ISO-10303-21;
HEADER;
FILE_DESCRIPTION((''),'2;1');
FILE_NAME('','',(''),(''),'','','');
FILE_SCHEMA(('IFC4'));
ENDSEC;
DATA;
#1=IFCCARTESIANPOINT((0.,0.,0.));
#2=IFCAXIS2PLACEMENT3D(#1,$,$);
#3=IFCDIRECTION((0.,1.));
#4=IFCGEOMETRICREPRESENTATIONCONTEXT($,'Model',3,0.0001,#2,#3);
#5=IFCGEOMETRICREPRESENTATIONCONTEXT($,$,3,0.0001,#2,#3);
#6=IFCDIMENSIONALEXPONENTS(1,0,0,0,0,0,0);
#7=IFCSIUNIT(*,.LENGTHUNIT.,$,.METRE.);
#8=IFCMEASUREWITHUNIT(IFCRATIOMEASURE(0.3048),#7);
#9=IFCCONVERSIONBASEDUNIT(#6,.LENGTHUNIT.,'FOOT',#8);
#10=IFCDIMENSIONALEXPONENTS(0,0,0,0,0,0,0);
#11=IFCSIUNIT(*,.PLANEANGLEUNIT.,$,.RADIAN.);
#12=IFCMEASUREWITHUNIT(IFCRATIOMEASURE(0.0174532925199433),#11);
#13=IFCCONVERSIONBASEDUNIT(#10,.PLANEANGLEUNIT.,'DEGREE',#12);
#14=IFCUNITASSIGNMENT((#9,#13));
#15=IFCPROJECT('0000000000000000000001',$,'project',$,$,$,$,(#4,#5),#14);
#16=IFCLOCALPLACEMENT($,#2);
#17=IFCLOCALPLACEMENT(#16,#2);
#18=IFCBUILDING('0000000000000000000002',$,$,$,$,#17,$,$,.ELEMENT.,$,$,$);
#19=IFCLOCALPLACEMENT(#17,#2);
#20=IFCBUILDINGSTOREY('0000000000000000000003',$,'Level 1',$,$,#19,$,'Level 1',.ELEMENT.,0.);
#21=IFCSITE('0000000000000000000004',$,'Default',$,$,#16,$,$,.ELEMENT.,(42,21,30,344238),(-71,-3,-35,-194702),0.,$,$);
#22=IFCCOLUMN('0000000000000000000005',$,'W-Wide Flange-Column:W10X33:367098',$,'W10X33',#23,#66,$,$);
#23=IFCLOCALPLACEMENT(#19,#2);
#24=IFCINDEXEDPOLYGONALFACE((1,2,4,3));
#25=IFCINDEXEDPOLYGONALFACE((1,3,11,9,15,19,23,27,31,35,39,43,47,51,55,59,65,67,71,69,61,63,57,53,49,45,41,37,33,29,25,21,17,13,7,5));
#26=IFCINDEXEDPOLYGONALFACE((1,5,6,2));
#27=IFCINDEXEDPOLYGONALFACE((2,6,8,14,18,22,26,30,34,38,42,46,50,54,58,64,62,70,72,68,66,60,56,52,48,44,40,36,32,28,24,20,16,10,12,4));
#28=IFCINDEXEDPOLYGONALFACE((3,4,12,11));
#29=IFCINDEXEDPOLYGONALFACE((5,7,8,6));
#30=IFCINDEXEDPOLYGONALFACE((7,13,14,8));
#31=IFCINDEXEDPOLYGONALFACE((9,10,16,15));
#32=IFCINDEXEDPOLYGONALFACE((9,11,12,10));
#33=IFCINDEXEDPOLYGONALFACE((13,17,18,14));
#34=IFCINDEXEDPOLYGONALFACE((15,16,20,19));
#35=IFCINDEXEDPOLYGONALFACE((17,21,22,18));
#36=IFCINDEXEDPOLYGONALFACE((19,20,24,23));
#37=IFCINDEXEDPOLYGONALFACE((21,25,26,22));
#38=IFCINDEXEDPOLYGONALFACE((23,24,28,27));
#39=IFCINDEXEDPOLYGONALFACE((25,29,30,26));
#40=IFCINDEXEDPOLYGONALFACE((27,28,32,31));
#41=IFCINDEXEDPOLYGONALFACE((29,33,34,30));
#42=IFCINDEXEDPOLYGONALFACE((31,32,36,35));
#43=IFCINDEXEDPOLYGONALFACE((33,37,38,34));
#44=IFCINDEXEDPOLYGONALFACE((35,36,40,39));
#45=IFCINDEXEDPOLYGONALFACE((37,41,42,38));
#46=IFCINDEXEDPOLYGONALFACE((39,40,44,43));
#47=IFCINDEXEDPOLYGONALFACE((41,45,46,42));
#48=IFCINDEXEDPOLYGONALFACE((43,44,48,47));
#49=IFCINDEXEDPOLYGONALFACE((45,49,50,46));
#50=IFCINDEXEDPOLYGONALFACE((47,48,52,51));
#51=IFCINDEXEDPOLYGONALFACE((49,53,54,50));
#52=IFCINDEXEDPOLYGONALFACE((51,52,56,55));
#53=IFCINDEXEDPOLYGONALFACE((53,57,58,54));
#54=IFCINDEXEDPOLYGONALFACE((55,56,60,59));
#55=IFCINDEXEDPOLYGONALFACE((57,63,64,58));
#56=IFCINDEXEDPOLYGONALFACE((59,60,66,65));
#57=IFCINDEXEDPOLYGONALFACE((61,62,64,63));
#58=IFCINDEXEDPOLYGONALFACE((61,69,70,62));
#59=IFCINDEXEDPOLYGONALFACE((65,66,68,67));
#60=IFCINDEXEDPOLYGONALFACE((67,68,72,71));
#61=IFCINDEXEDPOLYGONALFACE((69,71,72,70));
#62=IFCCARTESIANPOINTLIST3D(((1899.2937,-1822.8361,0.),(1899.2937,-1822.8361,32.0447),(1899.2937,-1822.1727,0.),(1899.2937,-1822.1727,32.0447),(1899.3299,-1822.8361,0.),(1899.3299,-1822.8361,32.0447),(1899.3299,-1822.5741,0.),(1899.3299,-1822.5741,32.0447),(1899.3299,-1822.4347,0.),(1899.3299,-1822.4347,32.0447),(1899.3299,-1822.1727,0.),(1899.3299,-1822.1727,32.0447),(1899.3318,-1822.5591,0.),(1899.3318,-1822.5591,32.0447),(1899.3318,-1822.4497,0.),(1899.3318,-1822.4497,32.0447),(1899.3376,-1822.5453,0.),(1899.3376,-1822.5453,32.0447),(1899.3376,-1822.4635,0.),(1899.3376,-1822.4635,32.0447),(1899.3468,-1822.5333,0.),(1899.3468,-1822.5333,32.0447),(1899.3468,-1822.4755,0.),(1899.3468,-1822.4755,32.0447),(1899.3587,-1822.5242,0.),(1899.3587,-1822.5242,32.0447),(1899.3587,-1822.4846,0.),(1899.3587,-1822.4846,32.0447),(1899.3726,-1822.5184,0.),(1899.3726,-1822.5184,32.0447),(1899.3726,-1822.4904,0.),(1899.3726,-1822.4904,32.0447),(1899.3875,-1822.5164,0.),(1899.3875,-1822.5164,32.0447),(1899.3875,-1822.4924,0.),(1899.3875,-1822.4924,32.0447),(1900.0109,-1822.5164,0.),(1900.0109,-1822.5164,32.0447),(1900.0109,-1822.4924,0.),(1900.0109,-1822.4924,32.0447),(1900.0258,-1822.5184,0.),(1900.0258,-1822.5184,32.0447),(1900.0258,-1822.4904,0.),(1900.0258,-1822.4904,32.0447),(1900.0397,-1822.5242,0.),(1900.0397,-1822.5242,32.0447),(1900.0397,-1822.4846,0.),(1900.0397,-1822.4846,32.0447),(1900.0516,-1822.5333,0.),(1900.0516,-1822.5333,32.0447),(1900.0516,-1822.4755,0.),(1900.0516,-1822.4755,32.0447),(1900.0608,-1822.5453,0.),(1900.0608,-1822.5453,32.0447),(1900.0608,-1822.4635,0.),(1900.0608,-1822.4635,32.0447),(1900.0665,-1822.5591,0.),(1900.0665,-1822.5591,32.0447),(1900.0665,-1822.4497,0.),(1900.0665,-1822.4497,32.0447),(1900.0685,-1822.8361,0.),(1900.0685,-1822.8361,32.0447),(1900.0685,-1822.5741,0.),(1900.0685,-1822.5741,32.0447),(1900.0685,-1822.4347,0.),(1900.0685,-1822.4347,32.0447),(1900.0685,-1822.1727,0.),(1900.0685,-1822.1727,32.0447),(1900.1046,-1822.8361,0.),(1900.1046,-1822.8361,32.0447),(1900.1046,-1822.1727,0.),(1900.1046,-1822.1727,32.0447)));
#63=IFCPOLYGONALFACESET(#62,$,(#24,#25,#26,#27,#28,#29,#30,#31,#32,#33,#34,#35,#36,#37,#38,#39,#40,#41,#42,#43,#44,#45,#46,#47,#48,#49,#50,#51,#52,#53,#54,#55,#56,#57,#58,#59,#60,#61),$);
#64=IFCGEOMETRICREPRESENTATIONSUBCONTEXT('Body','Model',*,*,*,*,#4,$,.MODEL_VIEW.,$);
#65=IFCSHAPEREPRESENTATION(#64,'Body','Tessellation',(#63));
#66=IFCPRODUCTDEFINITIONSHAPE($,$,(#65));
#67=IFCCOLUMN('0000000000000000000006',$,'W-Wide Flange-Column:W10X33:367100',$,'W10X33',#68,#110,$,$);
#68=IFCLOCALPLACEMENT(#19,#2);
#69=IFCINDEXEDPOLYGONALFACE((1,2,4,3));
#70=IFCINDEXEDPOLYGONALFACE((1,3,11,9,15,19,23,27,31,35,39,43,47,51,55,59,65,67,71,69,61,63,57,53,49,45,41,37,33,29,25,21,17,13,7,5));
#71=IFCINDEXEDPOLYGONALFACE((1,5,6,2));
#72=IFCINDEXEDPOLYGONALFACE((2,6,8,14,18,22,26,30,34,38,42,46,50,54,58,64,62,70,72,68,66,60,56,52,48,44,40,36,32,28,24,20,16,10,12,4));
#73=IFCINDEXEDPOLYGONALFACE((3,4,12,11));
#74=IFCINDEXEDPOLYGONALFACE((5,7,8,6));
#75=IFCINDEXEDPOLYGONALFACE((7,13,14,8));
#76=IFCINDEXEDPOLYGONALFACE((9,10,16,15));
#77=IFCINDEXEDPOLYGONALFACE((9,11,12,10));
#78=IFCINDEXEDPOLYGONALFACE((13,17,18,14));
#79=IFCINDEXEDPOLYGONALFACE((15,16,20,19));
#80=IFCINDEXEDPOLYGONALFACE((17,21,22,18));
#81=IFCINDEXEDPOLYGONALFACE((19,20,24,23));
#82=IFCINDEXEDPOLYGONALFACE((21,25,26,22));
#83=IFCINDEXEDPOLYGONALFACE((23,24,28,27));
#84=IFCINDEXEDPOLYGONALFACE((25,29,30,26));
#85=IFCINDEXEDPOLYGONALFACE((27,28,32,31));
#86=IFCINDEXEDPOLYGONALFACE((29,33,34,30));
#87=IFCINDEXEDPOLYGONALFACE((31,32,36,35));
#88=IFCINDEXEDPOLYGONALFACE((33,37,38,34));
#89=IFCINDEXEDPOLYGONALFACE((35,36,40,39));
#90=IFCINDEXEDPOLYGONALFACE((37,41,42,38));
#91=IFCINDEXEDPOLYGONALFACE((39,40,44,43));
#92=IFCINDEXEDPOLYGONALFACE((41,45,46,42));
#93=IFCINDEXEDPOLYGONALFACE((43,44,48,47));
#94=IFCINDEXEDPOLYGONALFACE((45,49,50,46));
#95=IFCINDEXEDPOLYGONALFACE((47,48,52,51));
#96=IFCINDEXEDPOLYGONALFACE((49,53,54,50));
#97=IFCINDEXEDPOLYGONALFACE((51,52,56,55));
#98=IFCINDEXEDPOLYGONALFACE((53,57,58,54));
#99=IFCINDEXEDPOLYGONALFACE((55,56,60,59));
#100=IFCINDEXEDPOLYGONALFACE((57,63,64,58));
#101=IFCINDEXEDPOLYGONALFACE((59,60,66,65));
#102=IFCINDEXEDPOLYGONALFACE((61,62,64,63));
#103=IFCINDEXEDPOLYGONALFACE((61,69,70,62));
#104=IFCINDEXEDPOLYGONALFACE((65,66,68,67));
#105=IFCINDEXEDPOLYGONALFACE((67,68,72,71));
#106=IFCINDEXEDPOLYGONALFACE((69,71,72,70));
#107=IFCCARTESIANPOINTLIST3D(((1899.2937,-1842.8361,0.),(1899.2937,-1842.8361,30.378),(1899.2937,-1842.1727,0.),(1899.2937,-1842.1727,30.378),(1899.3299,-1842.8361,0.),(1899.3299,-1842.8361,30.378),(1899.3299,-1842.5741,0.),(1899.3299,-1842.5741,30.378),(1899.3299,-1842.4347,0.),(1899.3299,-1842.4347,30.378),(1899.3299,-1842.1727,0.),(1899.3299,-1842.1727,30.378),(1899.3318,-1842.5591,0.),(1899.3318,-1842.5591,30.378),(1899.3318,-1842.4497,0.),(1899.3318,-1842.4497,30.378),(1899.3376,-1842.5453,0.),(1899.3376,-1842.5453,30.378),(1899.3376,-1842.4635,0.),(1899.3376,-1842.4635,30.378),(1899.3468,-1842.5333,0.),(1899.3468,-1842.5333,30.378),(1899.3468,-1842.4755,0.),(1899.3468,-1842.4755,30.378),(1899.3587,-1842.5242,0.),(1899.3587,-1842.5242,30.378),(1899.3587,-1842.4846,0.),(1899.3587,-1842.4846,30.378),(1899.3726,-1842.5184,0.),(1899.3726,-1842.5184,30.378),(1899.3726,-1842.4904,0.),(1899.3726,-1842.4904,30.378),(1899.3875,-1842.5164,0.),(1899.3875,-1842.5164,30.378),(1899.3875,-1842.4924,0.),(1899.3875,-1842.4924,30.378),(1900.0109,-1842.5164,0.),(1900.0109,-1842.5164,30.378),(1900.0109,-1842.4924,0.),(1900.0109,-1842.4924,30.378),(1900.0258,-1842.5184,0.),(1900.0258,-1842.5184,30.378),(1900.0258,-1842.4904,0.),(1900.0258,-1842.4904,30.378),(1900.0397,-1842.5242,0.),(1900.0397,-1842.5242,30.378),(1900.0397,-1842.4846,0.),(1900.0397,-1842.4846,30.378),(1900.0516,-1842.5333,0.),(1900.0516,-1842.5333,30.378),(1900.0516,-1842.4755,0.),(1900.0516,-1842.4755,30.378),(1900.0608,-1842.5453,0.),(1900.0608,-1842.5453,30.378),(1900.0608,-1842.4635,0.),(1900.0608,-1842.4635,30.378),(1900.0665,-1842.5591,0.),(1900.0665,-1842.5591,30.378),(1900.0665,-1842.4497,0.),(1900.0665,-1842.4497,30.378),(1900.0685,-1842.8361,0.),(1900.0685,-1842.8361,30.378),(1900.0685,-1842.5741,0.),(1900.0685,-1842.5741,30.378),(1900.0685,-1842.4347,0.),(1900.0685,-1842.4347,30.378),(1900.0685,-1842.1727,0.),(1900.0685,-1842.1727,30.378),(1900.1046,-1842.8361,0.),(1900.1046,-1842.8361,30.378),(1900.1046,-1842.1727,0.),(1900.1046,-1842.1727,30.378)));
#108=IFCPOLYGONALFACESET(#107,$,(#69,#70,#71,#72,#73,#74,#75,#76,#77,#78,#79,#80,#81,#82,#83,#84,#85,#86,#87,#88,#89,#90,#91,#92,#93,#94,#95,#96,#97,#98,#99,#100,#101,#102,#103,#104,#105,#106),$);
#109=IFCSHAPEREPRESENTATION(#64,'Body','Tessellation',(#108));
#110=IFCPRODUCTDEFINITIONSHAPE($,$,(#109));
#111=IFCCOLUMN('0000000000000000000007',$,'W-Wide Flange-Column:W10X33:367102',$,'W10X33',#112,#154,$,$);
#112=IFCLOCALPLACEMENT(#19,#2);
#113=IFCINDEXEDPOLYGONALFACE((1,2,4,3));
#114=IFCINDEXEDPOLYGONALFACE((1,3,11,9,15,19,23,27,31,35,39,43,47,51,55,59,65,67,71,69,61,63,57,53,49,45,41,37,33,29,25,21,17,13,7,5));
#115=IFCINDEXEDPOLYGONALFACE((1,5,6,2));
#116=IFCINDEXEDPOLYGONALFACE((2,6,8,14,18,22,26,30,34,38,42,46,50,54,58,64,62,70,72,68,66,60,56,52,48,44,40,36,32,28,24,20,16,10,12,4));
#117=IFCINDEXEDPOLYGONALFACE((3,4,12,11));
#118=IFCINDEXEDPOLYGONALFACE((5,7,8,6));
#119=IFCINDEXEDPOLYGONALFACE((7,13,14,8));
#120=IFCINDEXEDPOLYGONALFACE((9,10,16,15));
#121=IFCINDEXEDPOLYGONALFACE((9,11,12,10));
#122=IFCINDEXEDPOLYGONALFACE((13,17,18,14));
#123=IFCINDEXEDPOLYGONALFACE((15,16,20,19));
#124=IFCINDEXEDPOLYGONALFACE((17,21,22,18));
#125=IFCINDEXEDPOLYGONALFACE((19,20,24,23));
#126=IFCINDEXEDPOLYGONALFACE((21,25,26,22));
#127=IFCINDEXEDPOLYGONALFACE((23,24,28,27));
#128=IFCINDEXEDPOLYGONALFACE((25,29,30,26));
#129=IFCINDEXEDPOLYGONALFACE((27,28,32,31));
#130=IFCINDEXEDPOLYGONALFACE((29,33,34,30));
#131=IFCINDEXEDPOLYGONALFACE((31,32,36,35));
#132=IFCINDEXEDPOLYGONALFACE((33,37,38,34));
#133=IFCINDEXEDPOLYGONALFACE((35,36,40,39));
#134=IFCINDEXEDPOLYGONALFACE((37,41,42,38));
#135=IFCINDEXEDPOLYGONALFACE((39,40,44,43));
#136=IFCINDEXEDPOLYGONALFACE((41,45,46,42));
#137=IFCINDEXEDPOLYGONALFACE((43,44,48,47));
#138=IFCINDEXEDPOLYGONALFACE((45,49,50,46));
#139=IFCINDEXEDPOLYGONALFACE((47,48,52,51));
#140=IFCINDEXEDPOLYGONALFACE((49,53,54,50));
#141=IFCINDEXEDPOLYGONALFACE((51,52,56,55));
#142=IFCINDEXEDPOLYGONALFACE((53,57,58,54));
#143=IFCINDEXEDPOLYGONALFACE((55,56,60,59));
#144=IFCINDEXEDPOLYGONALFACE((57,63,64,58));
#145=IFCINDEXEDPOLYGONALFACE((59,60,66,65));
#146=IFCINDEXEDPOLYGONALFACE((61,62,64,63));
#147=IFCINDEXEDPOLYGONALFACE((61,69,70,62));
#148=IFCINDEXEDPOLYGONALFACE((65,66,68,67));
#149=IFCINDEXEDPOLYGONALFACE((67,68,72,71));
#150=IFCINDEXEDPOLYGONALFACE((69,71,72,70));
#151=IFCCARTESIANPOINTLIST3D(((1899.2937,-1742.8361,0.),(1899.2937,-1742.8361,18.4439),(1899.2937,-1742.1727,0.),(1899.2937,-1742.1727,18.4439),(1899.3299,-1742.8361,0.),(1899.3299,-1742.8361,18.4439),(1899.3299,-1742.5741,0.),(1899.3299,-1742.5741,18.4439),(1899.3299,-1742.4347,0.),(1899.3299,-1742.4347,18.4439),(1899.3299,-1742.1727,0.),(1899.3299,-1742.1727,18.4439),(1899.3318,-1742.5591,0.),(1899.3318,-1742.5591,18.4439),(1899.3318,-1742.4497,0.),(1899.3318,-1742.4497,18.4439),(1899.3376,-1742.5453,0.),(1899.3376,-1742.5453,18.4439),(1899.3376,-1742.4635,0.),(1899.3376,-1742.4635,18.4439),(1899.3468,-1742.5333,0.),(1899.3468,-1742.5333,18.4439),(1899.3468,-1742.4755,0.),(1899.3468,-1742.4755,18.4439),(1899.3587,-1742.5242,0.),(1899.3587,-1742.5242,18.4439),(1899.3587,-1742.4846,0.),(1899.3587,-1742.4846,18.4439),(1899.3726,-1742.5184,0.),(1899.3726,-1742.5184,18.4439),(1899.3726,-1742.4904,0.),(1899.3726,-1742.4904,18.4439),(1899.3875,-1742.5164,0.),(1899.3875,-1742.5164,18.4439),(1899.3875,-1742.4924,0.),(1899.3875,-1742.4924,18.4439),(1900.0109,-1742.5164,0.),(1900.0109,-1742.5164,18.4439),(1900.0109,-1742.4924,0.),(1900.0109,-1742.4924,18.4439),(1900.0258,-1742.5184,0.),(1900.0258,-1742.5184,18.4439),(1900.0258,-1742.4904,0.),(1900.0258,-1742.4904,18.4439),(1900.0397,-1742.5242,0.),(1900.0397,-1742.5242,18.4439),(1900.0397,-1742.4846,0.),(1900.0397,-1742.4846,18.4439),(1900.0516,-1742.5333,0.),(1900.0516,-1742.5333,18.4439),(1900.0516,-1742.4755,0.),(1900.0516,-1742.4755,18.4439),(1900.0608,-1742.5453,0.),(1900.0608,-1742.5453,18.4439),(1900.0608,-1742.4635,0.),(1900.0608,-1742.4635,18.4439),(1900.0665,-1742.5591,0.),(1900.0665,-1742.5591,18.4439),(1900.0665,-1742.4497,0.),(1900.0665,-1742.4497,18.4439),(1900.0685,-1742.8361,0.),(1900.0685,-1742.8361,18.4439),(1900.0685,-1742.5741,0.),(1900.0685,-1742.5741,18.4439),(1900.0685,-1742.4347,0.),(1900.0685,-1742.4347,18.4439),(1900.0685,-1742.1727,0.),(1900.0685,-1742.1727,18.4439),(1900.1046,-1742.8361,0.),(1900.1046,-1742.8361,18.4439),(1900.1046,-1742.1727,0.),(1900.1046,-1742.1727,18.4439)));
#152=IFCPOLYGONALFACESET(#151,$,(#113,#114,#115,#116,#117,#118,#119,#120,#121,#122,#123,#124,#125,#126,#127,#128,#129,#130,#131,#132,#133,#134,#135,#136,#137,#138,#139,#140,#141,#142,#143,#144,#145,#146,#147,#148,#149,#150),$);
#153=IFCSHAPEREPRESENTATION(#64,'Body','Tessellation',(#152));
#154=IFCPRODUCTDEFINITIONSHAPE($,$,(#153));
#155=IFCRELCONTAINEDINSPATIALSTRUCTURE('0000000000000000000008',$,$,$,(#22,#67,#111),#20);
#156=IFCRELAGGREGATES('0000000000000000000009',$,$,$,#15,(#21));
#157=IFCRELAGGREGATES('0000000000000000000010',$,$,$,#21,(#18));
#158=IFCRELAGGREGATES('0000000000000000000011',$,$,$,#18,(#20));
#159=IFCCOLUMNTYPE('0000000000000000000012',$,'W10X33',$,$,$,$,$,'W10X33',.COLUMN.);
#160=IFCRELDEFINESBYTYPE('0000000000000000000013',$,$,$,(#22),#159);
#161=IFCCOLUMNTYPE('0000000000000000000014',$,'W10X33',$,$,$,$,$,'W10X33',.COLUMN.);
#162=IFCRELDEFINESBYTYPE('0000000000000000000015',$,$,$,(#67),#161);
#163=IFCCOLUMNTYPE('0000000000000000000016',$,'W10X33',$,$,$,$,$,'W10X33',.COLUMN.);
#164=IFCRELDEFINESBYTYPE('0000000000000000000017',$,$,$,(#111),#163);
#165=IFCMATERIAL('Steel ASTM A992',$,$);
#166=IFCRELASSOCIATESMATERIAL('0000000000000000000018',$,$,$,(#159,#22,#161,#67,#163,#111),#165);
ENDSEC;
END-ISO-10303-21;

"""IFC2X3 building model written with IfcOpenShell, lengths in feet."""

from ifc_helpers import new_model, entity, si_unit, converted_unit, direction, frame, frame_2d, origin, place, context, subcontext, project, spatial, i_section, extrude, source, transform, mapped, material, type_object, type_shapes, element, save


model = new_model("IFC2X3")

# Units and contexts
model_context = context("Model", 3, precision=0.0001, world=origin(), true_north=direction((0.0, 1.0)))
context_of_model = context(None, 3, precision=0.0001, world=origin(), true_north=direction((0.0, 1.0)))
body_context = subcontext(model_context, "Body", "Model", "MODEL_VIEW")
ifc_project = project(units=[converted_unit("LENGTHUNIT", "FOOT", entity("IfcRatioMeasure", 0.3048), si_unit("LENGTHUNIT", "METRE"), dimensions=[1, 0, 0, 0, 0, 0, 0]), converted_unit("PLANEANGLEUNIT", "DEGREE", entity("IfcRatioMeasure", 0.0174532925199433), si_unit("PLANEANGLEUNIT", "RADIAN"), dimensions=[0, 0, 0, 0, 0, 0, 0])], contexts=[model_context, context_of_model])

# Site, building, storey
site_placement = place(None, origin())
site = spatial("IfcSite", under=ifc_project, at=site_placement, Name="Default", CompositionType="ELEMENT", RefLatitude=(42, 21, 30, 344238), RefLongitude=(-71, -3, -35, -194702), RefElevation=0.0)
building_placement = place(site_placement, origin())
building = spatial("IfcBuilding", under=site, at=building_placement, CompositionType="ELEMENT")
storey_placement = place(building_placement, origin())
storey = spatial("IfcBuildingStorey", under=building, at=storey_placement, Name="Level 1", LongName="Level 1", CompositionType="ELEMENT", Elevation=0.0)

# Columns
ifc_material_1 = material(Name="Steel ASTM A992")
column_type_1 = type_object("IfcColumnType", Name="W10X33", ElementType="W10X33", PredefinedType="COLUMN", material=ifc_material_1)
shared_shape_1 = source(origin(), body_context, "Body", "SweptSolid", [
    extrude(i_section(OverallWidth=0.6634, OverallDepth=0.8109, WebThickness=0.0241, FlangeThickness=0.0361, FilletRadius=0.0576, at=frame_2d((0.0, 0.0), x_axis=(1.0, 0.0))), frame((1899.6992, -1822.5044, 0.0), z_axis=(0.0, 0.0, 1.0), x_axis=(0.0, -1.0, 0.0)), (0.0, 0.0, 1.0), 32.0447),
])
type_shapes(column_type_1, [shared_shape_1])
column_1_placement = place(storey_placement, origin())
element("IfcColumn", 1, at=column_1_placement, inside=storey, type_object=column_type_1, material=ifc_material_1, Name="W-Wide Flange-Column:W10X33:367098", ObjectType="W10X33", context=body_context, shape_type="MappedRepresentation", body=[
    mapped(shared_shape_1, transform((0.0, 0.0, 0.0), scale=1.0)),
])
column_type_2 = type_object("IfcColumnType", Name="W10X33", ElementType="W10X33", PredefinedType="COLUMN", material=ifc_material_1)
shared_shape_2 = source(origin(), body_context, "Body", "SweptSolid", [
    extrude(i_section(OverallWidth=0.6634, OverallDepth=0.8109, WebThickness=0.0241, FlangeThickness=0.0361, FilletRadius=0.0576, at=frame_2d((0.0, 0.0), x_axis=(1.0, 0.0))), frame((1899.6992, -1842.5044, 0.0), z_axis=(0.0, 0.0, 1.0), x_axis=(0.0, -1.0, 0.0)), (0.0, 0.0, 1.0), 30.378),
])
type_shapes(column_type_2, [shared_shape_2])
column_2_placement = place(storey_placement, origin())
element("IfcColumn", 2, at=column_2_placement, inside=storey, type_object=column_type_2, material=ifc_material_1, Name="W-Wide Flange-Column:W10X33:367100", ObjectType="W10X33", context=body_context, shape_type="MappedRepresentation", body=[
    mapped(shared_shape_2, transform((0.0, 0.0, 0.0), scale=1.0)),
])
column_type_3 = type_object("IfcColumnType", Name="W10X33", ElementType="W10X33", PredefinedType="COLUMN", material=ifc_material_1)
shared_shape_3 = source(origin(), body_context, "Body", "SweptSolid", [
    extrude(i_section(OverallWidth=0.6634, OverallDepth=0.8109, WebThickness=0.0241, FlangeThickness=0.0361, FilletRadius=0.0576, at=frame_2d((0.0, 0.0), x_axis=(1.0, 0.0))), frame((1899.6992, -1742.5044, 0.0), z_axis=(0.0, 0.0, 1.0), x_axis=(0.0, -1.0, 0.0)), (0.0, 0.0, 1.0), 18.4439),
])
type_shapes(column_type_3, [shared_shape_3])
column_3_placement = place(storey_placement, origin())
element("IfcColumn", 3, at=column_3_placement, inside=storey, type_object=column_type_3, material=ifc_material_1, Name="W-Wide Flange-Column:W10X33:367102", ObjectType="W10X33", context=body_context, shape_type="MappedRepresentation", body=[
    mapped(shared_shape_3, transform((0.0, 0.0, 0.0), scale=1.0)),
])

save(model, "model.ifc")
